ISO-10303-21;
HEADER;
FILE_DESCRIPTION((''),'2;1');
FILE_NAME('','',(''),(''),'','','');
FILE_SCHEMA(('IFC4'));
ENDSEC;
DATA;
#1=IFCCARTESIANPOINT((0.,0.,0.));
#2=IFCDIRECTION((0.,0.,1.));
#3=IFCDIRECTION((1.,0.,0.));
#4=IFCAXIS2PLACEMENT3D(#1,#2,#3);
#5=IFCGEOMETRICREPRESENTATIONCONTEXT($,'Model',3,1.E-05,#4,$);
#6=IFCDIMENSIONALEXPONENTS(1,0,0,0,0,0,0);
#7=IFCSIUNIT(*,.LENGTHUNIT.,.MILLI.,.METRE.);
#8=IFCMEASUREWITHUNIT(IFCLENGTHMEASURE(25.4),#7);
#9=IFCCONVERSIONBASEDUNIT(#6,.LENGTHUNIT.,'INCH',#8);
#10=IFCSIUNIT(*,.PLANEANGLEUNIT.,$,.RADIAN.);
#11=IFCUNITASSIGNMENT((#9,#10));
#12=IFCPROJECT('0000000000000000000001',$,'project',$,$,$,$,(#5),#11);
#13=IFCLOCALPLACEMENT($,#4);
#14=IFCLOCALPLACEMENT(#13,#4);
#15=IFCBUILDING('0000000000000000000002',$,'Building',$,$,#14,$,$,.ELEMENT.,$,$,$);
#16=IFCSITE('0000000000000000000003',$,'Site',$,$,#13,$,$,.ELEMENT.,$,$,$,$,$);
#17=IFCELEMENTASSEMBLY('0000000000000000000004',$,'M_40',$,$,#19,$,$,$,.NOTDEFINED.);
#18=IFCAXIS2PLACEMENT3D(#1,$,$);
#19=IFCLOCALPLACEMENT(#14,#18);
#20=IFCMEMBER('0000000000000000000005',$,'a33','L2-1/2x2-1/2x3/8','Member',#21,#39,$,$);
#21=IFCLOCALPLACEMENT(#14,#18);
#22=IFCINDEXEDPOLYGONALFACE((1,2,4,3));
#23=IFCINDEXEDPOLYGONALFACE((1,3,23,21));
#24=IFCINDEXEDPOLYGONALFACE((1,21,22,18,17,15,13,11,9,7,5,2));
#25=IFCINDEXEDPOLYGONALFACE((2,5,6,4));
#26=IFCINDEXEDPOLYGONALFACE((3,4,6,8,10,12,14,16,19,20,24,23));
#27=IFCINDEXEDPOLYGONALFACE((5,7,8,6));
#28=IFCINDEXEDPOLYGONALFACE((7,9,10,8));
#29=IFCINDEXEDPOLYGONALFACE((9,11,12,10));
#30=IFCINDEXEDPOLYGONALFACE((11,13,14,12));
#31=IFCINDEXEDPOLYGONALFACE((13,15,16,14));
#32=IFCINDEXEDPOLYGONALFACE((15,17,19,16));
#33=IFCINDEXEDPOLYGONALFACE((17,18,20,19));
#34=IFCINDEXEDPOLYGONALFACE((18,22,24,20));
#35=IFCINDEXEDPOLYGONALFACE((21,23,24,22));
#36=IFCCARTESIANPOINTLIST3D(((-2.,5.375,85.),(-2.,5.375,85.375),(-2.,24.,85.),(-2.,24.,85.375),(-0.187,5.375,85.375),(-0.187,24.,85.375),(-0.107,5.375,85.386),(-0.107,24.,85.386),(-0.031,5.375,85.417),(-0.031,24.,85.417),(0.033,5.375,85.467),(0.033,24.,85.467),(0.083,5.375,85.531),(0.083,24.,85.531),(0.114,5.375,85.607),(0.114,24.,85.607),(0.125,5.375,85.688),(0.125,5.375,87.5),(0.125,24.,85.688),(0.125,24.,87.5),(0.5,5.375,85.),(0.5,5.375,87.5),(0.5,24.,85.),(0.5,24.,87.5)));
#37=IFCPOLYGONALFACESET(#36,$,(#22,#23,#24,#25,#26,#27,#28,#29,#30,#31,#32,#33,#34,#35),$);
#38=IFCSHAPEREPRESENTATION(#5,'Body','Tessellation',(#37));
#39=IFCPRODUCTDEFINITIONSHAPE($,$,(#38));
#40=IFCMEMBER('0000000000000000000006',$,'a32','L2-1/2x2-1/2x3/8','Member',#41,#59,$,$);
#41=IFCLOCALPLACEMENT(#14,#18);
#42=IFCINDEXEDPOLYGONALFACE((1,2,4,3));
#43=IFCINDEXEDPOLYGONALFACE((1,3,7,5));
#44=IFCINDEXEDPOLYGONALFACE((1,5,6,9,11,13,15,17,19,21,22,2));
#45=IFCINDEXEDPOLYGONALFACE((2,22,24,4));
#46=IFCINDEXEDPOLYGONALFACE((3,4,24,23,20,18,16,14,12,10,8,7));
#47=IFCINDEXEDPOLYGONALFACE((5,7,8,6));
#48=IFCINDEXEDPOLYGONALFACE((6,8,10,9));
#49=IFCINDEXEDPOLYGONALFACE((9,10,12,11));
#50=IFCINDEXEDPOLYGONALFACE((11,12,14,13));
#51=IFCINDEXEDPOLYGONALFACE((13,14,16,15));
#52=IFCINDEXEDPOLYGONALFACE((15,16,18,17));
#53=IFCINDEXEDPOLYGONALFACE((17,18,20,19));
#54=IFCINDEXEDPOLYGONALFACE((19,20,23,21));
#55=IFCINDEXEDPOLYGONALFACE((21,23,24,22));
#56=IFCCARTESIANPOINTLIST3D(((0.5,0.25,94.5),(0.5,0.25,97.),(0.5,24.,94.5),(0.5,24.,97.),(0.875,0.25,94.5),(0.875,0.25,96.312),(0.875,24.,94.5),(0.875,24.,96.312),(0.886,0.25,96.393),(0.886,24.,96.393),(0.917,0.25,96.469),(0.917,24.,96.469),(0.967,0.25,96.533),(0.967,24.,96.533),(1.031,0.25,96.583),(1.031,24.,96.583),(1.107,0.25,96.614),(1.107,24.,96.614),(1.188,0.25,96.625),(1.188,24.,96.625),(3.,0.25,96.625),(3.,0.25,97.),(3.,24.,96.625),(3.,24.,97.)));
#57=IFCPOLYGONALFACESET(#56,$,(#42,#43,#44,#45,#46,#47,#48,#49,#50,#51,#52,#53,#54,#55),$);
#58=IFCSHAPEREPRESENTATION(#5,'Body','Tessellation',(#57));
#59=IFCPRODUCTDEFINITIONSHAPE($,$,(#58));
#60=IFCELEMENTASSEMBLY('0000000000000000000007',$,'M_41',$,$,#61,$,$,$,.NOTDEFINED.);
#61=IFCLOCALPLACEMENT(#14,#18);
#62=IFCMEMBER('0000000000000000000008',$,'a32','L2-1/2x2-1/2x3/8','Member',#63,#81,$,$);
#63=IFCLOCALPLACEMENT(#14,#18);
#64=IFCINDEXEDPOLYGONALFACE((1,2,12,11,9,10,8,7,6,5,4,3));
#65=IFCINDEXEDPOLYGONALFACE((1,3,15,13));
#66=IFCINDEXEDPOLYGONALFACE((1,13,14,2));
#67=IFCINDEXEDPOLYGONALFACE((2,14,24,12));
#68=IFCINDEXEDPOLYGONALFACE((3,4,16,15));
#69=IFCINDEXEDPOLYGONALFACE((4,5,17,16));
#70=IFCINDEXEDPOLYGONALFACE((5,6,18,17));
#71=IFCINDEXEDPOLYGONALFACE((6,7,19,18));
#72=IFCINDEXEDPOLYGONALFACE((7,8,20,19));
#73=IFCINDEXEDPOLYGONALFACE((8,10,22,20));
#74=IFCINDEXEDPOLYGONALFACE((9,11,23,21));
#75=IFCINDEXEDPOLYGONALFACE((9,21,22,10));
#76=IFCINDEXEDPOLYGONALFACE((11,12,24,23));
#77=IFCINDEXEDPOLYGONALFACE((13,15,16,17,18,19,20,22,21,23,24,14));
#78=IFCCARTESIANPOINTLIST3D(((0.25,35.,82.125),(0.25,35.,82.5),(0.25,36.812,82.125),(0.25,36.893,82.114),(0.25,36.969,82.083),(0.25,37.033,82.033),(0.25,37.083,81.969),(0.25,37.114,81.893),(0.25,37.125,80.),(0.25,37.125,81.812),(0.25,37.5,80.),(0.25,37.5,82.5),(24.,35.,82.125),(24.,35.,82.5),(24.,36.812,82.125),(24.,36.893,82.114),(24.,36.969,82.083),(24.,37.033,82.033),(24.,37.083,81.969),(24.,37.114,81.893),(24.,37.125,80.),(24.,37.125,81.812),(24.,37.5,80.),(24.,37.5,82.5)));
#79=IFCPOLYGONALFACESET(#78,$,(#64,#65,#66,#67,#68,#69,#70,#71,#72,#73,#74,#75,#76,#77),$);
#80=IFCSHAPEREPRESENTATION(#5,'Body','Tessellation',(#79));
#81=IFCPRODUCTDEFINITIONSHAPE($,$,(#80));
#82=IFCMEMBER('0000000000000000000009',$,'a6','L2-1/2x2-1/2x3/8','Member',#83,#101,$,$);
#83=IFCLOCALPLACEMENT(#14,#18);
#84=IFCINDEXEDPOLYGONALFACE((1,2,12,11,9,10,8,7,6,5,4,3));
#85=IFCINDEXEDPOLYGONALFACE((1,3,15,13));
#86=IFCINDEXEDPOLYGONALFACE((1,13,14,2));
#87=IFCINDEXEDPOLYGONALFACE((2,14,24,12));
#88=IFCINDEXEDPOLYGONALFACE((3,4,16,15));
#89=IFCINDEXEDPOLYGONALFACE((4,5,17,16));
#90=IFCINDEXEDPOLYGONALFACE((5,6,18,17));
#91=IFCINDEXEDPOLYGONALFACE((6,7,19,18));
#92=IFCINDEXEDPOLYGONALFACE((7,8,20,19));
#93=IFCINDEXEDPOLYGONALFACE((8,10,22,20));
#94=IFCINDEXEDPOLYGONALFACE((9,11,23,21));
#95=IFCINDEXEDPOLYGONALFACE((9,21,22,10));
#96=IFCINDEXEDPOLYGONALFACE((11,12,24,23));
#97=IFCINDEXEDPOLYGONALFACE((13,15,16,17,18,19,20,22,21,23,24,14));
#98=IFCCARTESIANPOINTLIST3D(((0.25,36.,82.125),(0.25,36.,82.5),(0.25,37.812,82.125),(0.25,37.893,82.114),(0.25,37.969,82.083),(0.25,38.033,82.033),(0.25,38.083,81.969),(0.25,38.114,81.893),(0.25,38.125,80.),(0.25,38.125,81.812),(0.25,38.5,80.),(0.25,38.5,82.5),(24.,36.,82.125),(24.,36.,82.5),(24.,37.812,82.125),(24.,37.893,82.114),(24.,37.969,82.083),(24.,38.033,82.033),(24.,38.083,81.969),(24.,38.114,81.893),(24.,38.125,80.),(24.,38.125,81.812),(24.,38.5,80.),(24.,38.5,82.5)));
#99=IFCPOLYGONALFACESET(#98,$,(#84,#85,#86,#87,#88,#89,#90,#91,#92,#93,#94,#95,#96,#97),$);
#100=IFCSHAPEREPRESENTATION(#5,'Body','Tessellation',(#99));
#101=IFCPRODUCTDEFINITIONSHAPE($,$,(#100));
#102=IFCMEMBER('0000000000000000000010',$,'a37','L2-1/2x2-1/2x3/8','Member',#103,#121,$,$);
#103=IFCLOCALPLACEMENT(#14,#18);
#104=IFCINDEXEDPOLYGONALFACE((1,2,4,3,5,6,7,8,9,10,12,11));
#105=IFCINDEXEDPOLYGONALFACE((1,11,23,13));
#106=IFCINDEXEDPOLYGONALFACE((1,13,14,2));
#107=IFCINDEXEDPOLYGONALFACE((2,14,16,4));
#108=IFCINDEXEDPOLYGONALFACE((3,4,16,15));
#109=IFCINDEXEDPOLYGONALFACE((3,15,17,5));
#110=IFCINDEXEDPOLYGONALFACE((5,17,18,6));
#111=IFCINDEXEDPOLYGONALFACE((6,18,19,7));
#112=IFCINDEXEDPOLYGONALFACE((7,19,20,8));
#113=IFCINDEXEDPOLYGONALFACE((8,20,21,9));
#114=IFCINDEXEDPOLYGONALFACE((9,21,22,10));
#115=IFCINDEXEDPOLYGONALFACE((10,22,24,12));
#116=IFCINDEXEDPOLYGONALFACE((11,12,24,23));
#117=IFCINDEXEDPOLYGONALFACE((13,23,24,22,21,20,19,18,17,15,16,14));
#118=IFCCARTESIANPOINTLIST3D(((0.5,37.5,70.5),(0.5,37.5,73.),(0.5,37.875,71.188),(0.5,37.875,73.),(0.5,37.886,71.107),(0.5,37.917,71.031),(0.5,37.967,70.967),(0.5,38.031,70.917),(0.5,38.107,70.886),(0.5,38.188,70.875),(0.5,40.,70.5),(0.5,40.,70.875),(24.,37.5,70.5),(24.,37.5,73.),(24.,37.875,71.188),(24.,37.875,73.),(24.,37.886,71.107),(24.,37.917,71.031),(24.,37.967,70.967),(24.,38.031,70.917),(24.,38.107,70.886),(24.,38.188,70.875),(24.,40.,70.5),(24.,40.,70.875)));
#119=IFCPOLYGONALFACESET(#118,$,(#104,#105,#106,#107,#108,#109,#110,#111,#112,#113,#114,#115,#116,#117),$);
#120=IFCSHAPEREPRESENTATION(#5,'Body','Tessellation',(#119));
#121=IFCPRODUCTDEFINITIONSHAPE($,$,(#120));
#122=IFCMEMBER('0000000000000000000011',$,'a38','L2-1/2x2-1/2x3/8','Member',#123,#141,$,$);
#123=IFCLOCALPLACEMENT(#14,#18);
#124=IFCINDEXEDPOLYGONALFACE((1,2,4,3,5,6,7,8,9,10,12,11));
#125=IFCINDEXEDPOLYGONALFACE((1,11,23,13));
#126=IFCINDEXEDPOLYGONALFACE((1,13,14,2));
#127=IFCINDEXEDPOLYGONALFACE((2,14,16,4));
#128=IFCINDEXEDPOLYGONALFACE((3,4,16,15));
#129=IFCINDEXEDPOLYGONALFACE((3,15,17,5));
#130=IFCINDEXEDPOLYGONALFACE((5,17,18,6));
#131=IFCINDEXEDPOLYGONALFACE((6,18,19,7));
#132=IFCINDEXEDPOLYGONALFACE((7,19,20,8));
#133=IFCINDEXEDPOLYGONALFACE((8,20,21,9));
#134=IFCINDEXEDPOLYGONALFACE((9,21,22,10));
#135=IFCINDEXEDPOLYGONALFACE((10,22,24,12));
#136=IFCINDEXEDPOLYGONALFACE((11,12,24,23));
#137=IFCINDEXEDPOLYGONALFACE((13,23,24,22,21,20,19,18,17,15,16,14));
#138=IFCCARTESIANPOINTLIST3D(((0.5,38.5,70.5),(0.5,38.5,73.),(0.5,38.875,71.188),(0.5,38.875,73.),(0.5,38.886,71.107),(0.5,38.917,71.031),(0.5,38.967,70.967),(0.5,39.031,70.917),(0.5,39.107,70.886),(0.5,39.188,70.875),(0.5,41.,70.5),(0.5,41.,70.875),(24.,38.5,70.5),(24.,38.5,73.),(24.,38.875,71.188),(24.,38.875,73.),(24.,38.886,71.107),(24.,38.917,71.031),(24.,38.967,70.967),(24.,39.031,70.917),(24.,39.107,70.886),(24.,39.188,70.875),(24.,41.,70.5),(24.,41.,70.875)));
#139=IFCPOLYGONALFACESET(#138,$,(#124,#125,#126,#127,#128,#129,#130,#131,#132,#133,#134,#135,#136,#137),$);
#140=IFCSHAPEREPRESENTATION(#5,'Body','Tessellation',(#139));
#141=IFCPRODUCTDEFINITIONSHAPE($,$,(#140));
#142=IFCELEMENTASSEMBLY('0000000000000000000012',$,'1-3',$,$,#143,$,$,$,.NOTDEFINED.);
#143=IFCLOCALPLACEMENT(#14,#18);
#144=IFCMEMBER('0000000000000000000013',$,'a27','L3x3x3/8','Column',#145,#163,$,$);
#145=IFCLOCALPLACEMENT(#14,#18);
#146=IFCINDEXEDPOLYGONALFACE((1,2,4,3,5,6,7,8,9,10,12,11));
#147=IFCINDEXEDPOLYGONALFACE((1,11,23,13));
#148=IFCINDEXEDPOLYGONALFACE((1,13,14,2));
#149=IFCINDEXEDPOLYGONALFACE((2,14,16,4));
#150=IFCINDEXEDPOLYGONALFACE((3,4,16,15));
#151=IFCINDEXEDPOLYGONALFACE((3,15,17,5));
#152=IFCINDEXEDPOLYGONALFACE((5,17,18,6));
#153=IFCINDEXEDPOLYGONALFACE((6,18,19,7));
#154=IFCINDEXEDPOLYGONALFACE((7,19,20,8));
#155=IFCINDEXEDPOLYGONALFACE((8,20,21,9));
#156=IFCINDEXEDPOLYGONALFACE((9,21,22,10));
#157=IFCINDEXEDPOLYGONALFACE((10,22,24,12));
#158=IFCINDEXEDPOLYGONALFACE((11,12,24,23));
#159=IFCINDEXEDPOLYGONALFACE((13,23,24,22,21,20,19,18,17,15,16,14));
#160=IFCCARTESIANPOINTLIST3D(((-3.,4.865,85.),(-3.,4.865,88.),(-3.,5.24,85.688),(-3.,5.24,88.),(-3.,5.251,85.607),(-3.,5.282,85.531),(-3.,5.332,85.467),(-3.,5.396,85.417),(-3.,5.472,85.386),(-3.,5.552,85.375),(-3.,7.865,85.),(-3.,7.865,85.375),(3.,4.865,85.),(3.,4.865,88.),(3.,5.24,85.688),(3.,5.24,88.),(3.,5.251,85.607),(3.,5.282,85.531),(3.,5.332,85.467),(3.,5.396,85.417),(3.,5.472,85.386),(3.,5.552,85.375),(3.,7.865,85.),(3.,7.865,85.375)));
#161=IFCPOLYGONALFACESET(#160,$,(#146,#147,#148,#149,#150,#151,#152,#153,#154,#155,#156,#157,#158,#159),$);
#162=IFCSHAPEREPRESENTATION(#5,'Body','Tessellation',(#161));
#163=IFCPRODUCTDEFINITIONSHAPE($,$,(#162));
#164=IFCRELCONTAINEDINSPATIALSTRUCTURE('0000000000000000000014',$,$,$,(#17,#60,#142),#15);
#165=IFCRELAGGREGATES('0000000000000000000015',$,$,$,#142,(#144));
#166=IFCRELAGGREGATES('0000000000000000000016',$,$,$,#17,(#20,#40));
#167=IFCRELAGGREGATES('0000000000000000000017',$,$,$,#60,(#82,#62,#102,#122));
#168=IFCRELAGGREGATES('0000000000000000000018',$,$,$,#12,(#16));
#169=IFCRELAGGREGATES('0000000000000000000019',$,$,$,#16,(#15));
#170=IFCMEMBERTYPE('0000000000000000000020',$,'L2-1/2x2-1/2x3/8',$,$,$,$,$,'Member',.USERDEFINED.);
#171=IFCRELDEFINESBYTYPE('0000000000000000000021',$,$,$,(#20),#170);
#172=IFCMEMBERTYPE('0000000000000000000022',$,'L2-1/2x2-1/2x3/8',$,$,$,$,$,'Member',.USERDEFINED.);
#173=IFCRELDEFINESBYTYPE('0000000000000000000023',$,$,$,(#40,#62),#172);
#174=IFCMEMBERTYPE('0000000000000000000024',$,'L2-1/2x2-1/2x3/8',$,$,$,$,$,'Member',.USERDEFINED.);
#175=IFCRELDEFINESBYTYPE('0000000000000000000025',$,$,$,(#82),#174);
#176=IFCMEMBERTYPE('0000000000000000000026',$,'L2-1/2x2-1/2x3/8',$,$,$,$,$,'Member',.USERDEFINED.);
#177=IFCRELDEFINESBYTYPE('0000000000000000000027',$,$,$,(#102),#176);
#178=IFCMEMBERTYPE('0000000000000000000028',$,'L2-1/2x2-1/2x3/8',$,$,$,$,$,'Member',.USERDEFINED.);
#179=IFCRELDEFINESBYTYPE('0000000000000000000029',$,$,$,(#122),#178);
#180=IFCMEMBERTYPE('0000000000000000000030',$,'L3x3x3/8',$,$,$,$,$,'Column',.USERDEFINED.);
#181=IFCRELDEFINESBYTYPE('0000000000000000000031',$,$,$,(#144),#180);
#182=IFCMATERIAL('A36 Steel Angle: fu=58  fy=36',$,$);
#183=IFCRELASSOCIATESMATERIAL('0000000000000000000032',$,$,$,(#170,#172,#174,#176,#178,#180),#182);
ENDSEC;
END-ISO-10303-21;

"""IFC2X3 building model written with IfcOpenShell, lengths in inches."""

from ifc_helpers import new_model, entity, si_unit, converted_unit, frame, frame_2d, origin_with_axes, place, context, project, spatial, l_section, transform_2d, derived_profile, extrude, source, transform, mapped, material, type_object, type_shapes, element, aggregate, save


model = new_model("IFC2X3")

# Units and contexts
model_context = context("Model", 3, precision=1e-05, world=origin_with_axes())
ifc_project = project(units=[converted_unit("LENGTHUNIT", "INCH", entity("IfcLengthMeasure", 25.4), si_unit("LENGTHUNIT", "METRE", prefix="MILLI"), dimensions=[1, 0, 0, 0, 0, 0, 0]), si_unit("PLANEANGLEUNIT", "RADIAN")], contexts=[model_context])

# Site, building
site_placement = place(None, origin_with_axes())
site = spatial("IfcSite", under=ifc_project, at=site_placement, Name="Site", CompositionType="ELEMENT")
building_placement = place(site_placement, origin_with_axes())
building = spatial("IfcBuilding", under=site, at=building_placement, Name="Building", CompositionType="ELEMENT")

# Element assemblies, members
assembly_1_placement = place(building_placement, frame((0.0, 0.0, 97.0), z_axis=(0.0, 0.0, -1.0), x_axis=(0.0, 1.0, 0.0)))
assembly_1 = element("IfcElementAssembly", 1, at=assembly_1_placement, inside=building, Name="M_40", PredefinedType="NOTDEFINED")
ifc_material_1 = material(Name="A36 Steel Angle: fu=58  fy=36")
member_type_1 = type_object("IfcMemberType", Name="L2-1/2x2-1/2x3/8", ElementType="Member", PredefinedType="USERDEFINED", material=ifc_material_1)
shared_shape_1 = source(origin_with_axes(), model_context, "Body", "SweptSolid", [
    extrude(derived_profile(l_section(Depth=2.5, Width=2.5, Thickness=0.375, FilletRadius=0.312, at=frame_2d((1.25, 1.25), x_axis=(1.0, 0.0))), transform_2d((0.0, 0.0), x_axis=(-1.0, 0.0), y_axis=(0.0, 1.0))), frame((0.0, 0.0, 0.0), z_axis=(1.0, 0.0, 0.0), x_axis=(0.0, 1.0, 0.0)), (0.0, 0.0, 1.0), 18.625),
])
type_shapes(member_type_1, [shared_shape_1])
member_1_placement = place(assembly_1_placement, frame((5.375, 0.5, 12.0), z_axis=(0.0, 0.0, -1.0), x_axis=(1.0, 0.0, 0.0)))
member_1 = element("IfcMember", 2, at=member_1_placement, type_object=member_type_1, Name="a33", Description="L2-1/2x2-1/2x3/8", ObjectType="Member", context=model_context, shape_type="MappedRepresentation", body=[
    mapped(shared_shape_1, transform((0.0, 0.0, 0.0), scale=1.0)),
])
member_type_2 = type_object("IfcMemberType", Name="L2-1/2x2-1/2x3/8", ElementType="Member", PredefinedType="USERDEFINED", material=ifc_material_1)
shared_shape_2 = source(origin_with_axes(), model_context, "Body", "SweptSolid", [
    extrude(l_section(Depth=2.5, Width=2.5, Thickness=0.375, FilletRadius=0.312, at=frame_2d((1.25, 1.25), x_axis=(1.0, 0.0))), frame((0.0, 0.0, 0.0), z_axis=(1.0, 0.0, 0.0), x_axis=(0.0, 1.0, 0.0)), (0.0, 0.0, 1.0), 23.75),
])
type_shapes(member_type_2, [shared_shape_2])
member_2_placement = place(assembly_1_placement, frame((0.25, 0.5, 0.0), z_axis=(0.0, 0.0, 1.0), x_axis=(1.0, 0.0, 0.0)))
member_2 = element("IfcMember", 3, at=member_2_placement, type_object=member_type_2, Name="a32", Description="L2-1/2x2-1/2x3/8", ObjectType="Member", context=model_context, shape_type="MappedRepresentation", body=[
    mapped(shared_shape_2, transform((0.0, 0.0, 0.0), scale=1.0)),
])
assembly_2_placement = place(building_placement, frame((0.0, 38.0, 82.5), z_axis=(0.0, 0.0, -1.0), x_axis=(1.0, 0.0, 0.0)))
assembly_2 = element("IfcElementAssembly", 4, at=assembly_2_placement, inside=building, Name="M_41", PredefinedType="NOTDEFINED")
member_3_placement = place(assembly_2_placement, frame((0.25, 0.5, 0.0), z_axis=(0.0, 0.0, 1.0), x_axis=(1.0, 0.0, 0.0)))
member_3 = element("IfcMember", 5, at=member_3_placement, type_object=member_type_2, Name="a32", Description="L2-1/2x2-1/2x3/8", ObjectType="Member", context=model_context, shape_type="MappedRepresentation", body=[
    mapped(shared_shape_2, transform((0.0, 0.0, 0.0), scale=1.0)),
])
member_type_3 = type_object("IfcMemberType", Name="L2-1/2x2-1/2x3/8", ElementType="Member", PredefinedType="USERDEFINED", material=ifc_material_1)
shared_shape_3 = source(origin_with_axes(), model_context, "Body", "SweptSolid", [
    extrude(derived_profile(l_section(Depth=2.5, Width=2.5, Thickness=0.375, FilletRadius=0.312, at=frame_2d((1.25, 1.25), x_axis=(1.0, 0.0))), transform_2d((0.0, 0.0), x_axis=(-1.0, 0.0), y_axis=(0.0, 1.0))), frame((0.0, 0.0, 0.0), z_axis=(1.0, 0.0, 0.0), x_axis=(0.0, 1.0, 0.0)), (0.0, 0.0, 1.0), 23.75),
])
type_shapes(member_type_3, [shared_shape_3])
member_4_placement = place(assembly_2_placement, frame((0.25, -0.5, 0.0), z_axis=(0.0, 0.0, 1.0), x_axis=(1.0, 0.0, 0.0)))
member_4 = element("IfcMember", 6, at=member_4_placement, type_object=member_type_3, Name="a6", Description="L2-1/2x2-1/2x3/8", ObjectType="Member", context=model_context, shape_type="MappedRepresentation", body=[
    mapped(shared_shape_3, transform((0.0, 0.0, 0.0), scale=1.0)),
])
member_type_4 = type_object("IfcMemberType", Name="L2-1/2x2-1/2x3/8", ElementType="Member", PredefinedType="USERDEFINED", material=ifc_material_1)
shared_shape_4 = source(origin_with_axes(), model_context, "Body", "SweptSolid", [
    extrude(derived_profile(l_section(Depth=2.5, Width=2.5, Thickness=0.375, FilletRadius=0.312, at=frame_2d((1.25, 1.25), x_axis=(1.0, 0.0))), transform_2d((0.0, 0.0), x_axis=(-1.0, 0.0), y_axis=(0.0, 1.0))), frame((0.0, 0.0, 0.0), z_axis=(1.0, 0.0, 0.0), x_axis=(0.0, 1.0, 0.0)), (0.0, 0.0, 1.0), 23.5),
])
type_shapes(member_type_4, [shared_shape_4])
member_5_placement = place(assembly_2_placement, frame((0.5, 0.5, 12.0), z_axis=(0.0, 0.0, -1.0), x_axis=(1.0, 0.0, 0.0)))
member_5 = element("IfcMember", 7, at=member_5_placement, type_object=member_type_4, Name="a37", Description="L2-1/2x2-1/2x3/8", ObjectType="Member", context=model_context, shape_type="MappedRepresentation", body=[
    mapped(shared_shape_4, transform((0.0, 0.0, 0.0), scale=1.0)),
])
member_type_5 = type_object("IfcMemberType", Name="L2-1/2x2-1/2x3/8", ElementType="Member", PredefinedType="USERDEFINED", material=ifc_material_1)
shared_shape_5 = source(origin_with_axes(), model_context, "Body", "SweptSolid", [
    extrude(l_section(Depth=2.5, Width=2.5, Thickness=0.375, FilletRadius=0.312, at=frame_2d((1.25, 1.25), x_axis=(1.0, 0.0))), frame((0.0, 0.0, 0.0), z_axis=(1.0, 0.0, 0.0), x_axis=(0.0, 1.0, 0.0)), (0.0, 0.0, 1.0), 23.5),
])
type_shapes(member_type_5, [shared_shape_5])
member_6_placement = place(assembly_2_placement, frame((24.0, -0.5, 12.0), z_axis=(0.0, -1.0, 0.0), x_axis=(-1.0, 0.0, 0.0)))
member_6 = element("IfcMember", 8, at=member_6_placement, type_object=member_type_5, Name="a38", Description="L2-1/2x2-1/2x3/8", ObjectType="Member", context=model_context, shape_type="MappedRepresentation", body=[
    mapped(shared_shape_5, transform((0.0, 0.0, 0.0), scale=1.0)),
])

# Element assembly, member
assembly_3_placement = place(building_placement, frame((0.0, 0.0, 54.5), z_axis=(0.0, -1.0, 0.0), x_axis=(0.0, 0.0, 1.0)))
assembly_3 = element("IfcElementAssembly", 9, at=assembly_3_placement, inside=building, Name="1-3", PredefinedType="NOTDEFINED")
member_type_6 = type_object("IfcMemberType", Name="L3x3x3/8", ElementType="Column", PredefinedType="USERDEFINED", material=ifc_material_1)
shared_shape_6 = source(origin_with_axes(), model_context, "Body", "SweptSolid", [
    extrude(derived_profile(l_section(Depth=3.0, Width=3.0, Thickness=0.375, FilletRadius=0.312, at=frame_2d((1.5, 1.5), x_axis=(1.0, 0.0))), transform_2d((0.0, 0.0), x_axis=(-1.0, 0.0), y_axis=(0.0, 1.0))), frame((0.0, 0.0, 0.0), z_axis=(1.0, 0.0, 0.0), x_axis=(0.0, 1.0, 0.0)), (0.0, 0.0, 1.0), 6.0),
])
type_shapes(member_type_6, [shared_shape_6])
member_7_placement = place(assembly_3_placement, frame((30.5, -3.0, -4.865), z_axis=(0.0, 0.0, -1.0), x_axis=(0.0, 1.0, 0.0)))
member_7 = element("IfcMember", 10, at=member_7_placement, type_object=member_type_6, Name="a27", Description="L3x3x3/8", ObjectType="Column", context=model_context, shape_type="MappedRepresentation", body=[
    mapped(shared_shape_6, transform((0.0, 0.0, 0.0), scale=1.0)),
])
aggregate(assembly_3, [member_7])

aggregate(assembly_1, [member_1, member_2])

aggregate(assembly_2, [member_4, member_3, member_5, member_6])

save(model, "model.ifc")
